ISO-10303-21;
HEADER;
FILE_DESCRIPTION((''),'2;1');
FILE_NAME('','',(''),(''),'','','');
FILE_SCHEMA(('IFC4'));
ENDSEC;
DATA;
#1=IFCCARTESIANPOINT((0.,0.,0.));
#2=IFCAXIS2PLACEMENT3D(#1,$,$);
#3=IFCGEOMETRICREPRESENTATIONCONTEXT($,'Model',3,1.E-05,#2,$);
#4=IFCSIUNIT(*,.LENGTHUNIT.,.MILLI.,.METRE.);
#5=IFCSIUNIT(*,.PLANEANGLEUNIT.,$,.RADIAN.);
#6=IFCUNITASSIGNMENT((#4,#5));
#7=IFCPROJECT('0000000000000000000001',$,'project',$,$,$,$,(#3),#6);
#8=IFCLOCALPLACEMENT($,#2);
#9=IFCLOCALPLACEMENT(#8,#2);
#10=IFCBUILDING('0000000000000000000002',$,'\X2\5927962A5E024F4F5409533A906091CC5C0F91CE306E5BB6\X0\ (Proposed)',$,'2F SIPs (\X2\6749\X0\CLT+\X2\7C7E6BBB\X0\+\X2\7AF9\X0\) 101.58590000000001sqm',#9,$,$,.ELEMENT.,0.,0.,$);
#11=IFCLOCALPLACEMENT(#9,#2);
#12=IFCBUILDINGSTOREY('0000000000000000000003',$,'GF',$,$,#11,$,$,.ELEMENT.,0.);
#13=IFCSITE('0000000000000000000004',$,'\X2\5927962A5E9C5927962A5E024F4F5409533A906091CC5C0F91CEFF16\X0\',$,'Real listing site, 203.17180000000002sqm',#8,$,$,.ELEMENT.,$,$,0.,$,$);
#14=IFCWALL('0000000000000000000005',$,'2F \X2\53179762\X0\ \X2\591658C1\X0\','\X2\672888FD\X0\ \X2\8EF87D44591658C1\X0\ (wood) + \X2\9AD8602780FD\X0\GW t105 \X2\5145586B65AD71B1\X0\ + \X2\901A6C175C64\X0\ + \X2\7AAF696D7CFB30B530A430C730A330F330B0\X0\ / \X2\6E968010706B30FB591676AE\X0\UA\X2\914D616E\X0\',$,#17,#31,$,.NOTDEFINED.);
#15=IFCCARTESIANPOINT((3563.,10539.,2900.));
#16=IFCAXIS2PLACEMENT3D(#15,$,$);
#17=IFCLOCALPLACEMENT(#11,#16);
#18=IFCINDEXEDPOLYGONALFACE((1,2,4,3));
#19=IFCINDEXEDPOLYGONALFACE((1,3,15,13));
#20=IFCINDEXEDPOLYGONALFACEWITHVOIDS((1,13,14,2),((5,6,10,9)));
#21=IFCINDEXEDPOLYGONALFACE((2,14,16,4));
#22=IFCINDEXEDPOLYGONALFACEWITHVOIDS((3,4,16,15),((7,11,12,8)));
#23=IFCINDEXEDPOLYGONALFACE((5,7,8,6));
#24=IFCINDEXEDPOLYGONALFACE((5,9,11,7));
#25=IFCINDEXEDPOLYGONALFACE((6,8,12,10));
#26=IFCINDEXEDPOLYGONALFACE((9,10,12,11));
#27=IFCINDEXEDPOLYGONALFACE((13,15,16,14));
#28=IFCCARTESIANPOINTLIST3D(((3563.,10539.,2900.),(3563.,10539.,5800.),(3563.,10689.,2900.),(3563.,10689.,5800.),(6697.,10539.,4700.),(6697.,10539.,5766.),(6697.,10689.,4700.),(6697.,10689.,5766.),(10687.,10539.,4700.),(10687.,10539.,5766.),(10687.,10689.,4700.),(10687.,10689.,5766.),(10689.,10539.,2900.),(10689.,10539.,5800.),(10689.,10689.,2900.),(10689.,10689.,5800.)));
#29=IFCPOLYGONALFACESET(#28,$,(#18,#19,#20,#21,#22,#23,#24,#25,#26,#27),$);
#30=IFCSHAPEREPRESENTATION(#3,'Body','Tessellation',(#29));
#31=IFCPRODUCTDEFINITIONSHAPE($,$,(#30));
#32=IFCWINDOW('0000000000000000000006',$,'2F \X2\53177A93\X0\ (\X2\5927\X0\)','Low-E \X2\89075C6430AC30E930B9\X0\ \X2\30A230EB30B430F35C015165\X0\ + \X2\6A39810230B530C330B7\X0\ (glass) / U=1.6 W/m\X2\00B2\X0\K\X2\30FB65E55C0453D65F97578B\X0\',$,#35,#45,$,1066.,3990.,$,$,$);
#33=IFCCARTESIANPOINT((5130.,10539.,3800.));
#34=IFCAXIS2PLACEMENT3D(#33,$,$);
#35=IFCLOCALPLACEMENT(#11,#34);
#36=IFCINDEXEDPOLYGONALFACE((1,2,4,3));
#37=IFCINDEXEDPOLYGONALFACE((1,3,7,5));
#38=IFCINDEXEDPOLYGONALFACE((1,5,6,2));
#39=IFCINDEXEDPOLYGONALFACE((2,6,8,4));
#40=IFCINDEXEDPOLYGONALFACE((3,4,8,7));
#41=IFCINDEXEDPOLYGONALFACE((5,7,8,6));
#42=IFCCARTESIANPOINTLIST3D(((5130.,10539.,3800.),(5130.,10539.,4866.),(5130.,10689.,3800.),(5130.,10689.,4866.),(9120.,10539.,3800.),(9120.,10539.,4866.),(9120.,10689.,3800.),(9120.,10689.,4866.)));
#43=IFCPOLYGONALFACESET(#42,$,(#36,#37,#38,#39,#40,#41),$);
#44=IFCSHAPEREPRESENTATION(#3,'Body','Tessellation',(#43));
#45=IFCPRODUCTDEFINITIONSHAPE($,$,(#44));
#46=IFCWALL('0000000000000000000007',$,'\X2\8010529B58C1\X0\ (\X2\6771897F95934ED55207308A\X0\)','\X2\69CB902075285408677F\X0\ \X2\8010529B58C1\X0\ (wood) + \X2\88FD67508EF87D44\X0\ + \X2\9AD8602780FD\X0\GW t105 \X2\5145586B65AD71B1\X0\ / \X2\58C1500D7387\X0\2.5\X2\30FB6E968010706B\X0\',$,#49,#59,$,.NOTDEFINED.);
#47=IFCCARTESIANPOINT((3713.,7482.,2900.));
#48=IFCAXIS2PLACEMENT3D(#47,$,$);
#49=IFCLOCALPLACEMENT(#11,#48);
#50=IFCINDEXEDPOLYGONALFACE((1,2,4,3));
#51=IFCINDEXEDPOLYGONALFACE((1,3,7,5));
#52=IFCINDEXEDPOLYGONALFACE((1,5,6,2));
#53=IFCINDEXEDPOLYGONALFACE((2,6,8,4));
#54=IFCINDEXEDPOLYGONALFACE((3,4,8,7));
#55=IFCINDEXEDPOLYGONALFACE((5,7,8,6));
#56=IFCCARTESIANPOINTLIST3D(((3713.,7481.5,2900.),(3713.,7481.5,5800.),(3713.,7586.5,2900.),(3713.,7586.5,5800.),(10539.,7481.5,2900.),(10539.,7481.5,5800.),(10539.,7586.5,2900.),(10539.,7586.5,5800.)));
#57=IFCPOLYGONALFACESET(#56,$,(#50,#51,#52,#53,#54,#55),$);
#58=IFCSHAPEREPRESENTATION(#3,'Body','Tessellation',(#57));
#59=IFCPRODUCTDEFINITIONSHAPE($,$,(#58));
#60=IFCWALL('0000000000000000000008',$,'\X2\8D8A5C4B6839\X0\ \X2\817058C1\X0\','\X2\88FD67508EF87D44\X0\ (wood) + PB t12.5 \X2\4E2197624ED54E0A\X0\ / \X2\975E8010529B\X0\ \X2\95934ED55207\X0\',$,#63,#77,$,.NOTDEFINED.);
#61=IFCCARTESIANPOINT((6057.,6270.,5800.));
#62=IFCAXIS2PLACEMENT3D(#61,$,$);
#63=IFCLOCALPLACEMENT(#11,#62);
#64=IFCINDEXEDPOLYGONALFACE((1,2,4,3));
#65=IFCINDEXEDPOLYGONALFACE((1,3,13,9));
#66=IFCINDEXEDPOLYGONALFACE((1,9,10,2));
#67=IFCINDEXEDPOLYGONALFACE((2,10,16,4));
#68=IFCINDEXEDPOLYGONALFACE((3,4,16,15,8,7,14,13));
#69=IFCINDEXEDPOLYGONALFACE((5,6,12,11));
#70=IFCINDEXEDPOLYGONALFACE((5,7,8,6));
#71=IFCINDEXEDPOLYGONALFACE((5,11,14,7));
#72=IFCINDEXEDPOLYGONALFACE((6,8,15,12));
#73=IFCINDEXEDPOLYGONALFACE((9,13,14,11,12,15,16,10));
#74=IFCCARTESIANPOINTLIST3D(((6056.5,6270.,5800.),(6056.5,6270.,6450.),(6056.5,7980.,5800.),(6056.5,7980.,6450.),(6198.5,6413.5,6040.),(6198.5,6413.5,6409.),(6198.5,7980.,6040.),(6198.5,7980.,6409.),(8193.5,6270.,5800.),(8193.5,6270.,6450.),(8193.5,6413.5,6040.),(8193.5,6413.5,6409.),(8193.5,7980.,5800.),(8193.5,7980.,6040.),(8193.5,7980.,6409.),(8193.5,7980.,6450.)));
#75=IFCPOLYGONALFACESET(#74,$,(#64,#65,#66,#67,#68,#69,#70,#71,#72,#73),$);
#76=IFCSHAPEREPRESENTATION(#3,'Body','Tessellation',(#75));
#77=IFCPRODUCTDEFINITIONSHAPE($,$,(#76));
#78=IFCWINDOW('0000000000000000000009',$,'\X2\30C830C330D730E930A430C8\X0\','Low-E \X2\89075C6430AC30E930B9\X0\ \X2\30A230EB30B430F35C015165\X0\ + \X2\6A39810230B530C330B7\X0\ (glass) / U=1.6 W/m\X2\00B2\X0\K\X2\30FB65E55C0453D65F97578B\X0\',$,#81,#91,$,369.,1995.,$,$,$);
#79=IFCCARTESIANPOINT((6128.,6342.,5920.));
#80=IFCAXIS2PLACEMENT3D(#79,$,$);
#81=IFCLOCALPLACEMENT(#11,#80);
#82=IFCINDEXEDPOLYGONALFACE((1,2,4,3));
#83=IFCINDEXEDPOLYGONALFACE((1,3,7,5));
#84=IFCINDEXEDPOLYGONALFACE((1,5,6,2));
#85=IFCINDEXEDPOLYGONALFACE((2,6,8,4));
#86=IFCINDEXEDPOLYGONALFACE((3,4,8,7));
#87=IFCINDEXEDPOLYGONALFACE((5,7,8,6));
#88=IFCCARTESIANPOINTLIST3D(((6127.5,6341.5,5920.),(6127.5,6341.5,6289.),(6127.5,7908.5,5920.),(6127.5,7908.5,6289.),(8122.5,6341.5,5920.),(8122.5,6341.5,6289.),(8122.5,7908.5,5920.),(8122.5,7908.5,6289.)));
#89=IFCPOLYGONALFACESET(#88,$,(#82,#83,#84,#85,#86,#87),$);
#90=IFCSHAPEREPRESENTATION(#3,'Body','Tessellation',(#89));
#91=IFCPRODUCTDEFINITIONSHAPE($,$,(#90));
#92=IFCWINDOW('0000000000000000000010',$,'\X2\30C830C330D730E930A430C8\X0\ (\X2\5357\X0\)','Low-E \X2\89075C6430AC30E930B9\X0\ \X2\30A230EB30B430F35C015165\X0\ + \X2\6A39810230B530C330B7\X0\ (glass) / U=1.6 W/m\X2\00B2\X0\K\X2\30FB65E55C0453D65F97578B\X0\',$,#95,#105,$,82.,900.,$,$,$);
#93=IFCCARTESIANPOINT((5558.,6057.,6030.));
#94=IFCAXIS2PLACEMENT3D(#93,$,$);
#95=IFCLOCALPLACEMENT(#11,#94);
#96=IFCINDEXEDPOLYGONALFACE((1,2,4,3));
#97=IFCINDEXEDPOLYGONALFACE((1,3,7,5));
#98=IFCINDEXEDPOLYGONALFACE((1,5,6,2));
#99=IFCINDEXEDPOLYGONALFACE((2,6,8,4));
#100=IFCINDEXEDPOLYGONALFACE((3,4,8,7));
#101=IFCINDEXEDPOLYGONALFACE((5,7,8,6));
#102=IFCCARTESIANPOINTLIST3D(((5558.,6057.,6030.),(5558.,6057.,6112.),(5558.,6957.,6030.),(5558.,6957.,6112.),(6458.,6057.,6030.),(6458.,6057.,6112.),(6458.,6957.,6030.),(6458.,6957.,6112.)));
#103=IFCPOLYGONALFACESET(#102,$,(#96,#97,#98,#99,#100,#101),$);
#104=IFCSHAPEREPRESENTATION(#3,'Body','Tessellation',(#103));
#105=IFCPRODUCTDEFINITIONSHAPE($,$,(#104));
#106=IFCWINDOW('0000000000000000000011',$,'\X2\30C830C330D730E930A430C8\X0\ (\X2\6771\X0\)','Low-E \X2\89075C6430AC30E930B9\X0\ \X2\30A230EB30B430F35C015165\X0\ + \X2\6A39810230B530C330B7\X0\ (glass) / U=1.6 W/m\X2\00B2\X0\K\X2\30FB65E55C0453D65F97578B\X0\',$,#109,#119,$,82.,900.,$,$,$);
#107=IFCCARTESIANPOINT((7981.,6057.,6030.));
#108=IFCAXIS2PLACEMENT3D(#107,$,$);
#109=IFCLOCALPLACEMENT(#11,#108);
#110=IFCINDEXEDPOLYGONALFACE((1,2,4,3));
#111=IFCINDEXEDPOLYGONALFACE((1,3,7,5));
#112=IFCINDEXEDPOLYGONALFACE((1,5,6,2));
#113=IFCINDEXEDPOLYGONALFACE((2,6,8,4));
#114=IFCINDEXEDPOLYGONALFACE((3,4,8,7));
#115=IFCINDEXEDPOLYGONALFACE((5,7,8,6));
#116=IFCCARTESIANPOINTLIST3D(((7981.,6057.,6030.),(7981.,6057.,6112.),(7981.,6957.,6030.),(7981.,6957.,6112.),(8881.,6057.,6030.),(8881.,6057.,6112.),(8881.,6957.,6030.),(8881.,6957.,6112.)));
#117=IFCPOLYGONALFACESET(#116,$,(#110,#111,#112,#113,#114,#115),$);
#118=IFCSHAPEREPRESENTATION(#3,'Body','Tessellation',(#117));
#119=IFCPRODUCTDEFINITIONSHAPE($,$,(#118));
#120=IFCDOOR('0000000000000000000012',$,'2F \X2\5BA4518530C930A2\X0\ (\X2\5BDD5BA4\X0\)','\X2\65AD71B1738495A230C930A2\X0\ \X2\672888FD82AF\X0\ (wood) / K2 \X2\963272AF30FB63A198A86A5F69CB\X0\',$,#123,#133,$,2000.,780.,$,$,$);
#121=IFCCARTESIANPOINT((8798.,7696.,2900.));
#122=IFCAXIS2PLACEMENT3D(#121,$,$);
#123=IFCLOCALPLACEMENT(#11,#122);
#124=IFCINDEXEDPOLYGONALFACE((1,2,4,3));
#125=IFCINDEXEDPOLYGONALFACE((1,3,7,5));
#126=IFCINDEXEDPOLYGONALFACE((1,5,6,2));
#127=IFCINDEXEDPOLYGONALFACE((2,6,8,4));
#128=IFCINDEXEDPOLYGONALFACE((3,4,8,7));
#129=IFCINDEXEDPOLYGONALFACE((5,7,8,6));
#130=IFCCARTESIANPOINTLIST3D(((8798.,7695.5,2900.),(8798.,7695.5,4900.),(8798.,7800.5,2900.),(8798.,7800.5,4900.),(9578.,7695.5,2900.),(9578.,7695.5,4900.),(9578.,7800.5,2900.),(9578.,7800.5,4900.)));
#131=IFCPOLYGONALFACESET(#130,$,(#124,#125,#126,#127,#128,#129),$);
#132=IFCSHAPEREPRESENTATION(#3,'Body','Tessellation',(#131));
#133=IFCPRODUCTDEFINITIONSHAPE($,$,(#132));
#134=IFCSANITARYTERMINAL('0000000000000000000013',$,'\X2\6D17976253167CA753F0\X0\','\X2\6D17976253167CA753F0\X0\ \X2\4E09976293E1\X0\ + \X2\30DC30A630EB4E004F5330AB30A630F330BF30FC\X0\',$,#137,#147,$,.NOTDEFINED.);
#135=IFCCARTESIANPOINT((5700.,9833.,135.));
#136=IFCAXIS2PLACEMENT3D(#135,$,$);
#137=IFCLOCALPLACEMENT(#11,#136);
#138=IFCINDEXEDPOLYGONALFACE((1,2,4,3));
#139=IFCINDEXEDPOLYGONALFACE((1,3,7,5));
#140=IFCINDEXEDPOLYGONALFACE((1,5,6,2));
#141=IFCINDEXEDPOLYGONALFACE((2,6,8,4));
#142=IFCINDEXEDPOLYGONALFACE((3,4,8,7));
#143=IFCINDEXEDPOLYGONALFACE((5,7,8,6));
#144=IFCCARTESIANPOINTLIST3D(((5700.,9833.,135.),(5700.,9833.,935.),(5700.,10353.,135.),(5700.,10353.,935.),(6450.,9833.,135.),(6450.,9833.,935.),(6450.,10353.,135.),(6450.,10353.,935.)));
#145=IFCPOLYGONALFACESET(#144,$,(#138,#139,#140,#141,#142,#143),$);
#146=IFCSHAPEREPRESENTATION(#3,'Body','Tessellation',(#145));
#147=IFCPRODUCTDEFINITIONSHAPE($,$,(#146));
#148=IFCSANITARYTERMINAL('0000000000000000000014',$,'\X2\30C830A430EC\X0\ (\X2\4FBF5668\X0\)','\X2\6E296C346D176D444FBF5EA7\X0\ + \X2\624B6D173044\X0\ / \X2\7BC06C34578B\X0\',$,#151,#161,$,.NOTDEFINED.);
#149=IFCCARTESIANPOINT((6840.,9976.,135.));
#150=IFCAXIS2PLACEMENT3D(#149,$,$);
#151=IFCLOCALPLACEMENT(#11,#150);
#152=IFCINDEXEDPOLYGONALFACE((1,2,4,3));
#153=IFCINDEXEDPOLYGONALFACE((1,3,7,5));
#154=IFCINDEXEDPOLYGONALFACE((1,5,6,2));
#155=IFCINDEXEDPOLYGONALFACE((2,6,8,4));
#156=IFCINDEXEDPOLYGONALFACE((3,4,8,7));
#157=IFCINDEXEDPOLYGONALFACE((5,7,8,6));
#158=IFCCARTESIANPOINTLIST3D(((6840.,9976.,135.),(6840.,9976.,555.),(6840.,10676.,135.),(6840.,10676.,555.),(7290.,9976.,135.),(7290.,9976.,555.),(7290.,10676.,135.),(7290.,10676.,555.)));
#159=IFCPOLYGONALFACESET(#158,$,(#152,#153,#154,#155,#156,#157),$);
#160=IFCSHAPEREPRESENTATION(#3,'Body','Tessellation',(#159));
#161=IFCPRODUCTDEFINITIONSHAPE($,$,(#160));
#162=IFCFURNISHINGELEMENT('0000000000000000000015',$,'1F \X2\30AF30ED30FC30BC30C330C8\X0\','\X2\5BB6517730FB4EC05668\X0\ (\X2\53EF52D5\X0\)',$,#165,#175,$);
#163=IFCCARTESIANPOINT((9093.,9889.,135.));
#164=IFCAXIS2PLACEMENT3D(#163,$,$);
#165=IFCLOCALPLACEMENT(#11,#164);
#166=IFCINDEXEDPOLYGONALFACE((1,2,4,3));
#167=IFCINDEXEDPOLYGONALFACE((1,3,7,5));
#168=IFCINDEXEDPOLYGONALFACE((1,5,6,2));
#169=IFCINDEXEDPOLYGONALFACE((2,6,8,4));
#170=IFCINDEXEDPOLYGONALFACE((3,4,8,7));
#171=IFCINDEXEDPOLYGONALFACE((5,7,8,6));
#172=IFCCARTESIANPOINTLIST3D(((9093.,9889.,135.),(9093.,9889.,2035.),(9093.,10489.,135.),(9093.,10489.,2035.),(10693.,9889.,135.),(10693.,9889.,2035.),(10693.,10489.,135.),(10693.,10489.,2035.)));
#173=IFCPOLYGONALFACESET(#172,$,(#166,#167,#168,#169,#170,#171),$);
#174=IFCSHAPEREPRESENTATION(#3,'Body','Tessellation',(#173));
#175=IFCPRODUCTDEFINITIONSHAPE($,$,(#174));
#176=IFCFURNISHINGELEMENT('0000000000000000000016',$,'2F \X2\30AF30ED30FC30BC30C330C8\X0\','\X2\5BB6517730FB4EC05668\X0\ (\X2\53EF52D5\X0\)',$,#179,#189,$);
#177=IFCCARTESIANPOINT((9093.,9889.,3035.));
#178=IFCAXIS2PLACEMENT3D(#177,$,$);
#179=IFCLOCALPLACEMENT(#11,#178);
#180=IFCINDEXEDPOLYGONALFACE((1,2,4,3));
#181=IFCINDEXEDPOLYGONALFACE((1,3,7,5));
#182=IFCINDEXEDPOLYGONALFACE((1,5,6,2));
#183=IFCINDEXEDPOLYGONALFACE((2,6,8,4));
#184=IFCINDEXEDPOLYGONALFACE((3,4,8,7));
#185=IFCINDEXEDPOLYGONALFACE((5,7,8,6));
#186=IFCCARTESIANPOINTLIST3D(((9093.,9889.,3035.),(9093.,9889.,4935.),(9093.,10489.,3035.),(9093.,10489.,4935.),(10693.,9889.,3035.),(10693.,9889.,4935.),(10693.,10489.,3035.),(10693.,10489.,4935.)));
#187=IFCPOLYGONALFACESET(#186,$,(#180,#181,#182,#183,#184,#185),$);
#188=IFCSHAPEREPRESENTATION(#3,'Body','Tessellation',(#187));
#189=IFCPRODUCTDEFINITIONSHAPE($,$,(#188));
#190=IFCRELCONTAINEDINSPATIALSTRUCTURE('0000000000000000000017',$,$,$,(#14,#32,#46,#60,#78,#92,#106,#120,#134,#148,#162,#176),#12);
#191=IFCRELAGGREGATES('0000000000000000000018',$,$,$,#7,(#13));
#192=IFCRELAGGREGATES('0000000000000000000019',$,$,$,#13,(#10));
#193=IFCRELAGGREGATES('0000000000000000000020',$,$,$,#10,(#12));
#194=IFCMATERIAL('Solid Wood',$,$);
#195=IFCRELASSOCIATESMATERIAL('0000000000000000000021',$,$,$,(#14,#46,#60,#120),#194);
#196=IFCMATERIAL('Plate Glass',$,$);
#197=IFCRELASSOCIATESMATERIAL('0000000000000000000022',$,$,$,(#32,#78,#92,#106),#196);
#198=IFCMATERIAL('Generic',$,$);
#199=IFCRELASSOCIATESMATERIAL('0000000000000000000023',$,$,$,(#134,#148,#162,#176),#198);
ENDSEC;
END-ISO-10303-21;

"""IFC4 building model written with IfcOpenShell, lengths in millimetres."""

from ifc_helpers import new_model, si_unit, frame, frame_2d, origin, place, context, project, spatial, rectangle, extrude, material, element, fill, save


model = new_model("IFC4")

# Units and contexts
model_context = context("Model", 3, precision=1e-05, world=origin())
ifc_project = project(units=[si_unit("LENGTHUNIT", "METRE", prefix="MILLI"), si_unit("PLANEANGLEUNIT", "RADIAN")], contexts=[model_context])

# Site, building, storey
site_placement = place(None, origin())
site = spatial("IfcSite", under=ifc_project, at=site_placement, Name="大阪府大阪市住吉区遠里小野６", ObjectType="Real listing site, 203.17180000000002sqm", CompositionType="ELEMENT", RefElevation=0.0)
building_placement = place(site_placement, origin())
building = spatial("IfcBuilding", under=site, at=building_placement, Name="大阪市住吉区遠里小野の家 (Proposed)", ObjectType="2F SIPs (杉CLT+籾殻+竹) 101.58590000000001sqm", CompositionType="ELEMENT", ElevationOfRefHeight=0.0, ElevationOfTerrain=0.0)
storey_placement = place(building_placement, origin())
storey = spatial("IfcBuildingStorey", under=building, at=storey_placement, Name="GF", CompositionType="ELEMENT", Elevation=0.0)

# Wall, opening, window
ifc_material_1 = material(Name="Solid Wood")
wall_1_placement = place(storey_placement, frame((3563.0, 10539.0, 2900.0)))
wall_1 = element("IfcWall", 1, at=wall_1_placement, inside=storey, material=ifc_material_1, Name="2F 北面 外壁", Description="木製 軸組外壁 (wood) + 高性能GW t105 充填断熱 + 通気層 + 窯業系サイディング / 準耐火・外皮UA配慮", PredefinedType="NOTDEFINED", context=model_context, shape_type="SweptSolid", body=[
    extrude(rectangle(XDim=7126.0, YDim=150.0, at=frame_2d((3563.0, 75.0))), frame((3563.0, 10539.0, 2900.0)), (0.0, 0.0, 1.0), 2900.0),
])
opening_1_placement = place(storey_placement, frame((5130.0, 10539.0, 3800.0)))
opening_1 = element("IfcOpeningElement", 2, at=opening_1_placement, cuts=wall_1, PredefinedType="NOTDEFINED", context=model_context, shape_type="SweptSolid", body=[
    extrude(rectangle(XDim=3990.0, YDim=150.0, at=frame_2d((1995.0, 75.0))), frame((5130.0, 10539.0, 3800.0)), (0.0, 0.0, 1.0), 1066.0),
])
ifc_material_2 = material(Name="Plate Glass")
window_1_placement = place(storey_placement, frame((5130.0, 10539.0, 3800.0)))
window_1 = element("IfcWindow", 3, at=window_1_placement, inside=storey, material=ifc_material_2, Name="2F 北窓 (大)", Description="Low-E 複層ガラス アルゴン封入 + 樹脂サッシ (glass) / U=1.6 W/m²K・日射取得型", OverallHeight=1066.0, OverallWidth=3990.0, context=model_context, shape_type="SweptSolid", body=[
    extrude(rectangle(XDim=3990.0, YDim=150.0, at=frame_2d((1995.0, 75.0))), frame((5130.0, 10539.0, 3800.0)), (0.0, 0.0, 1.0), 1066.0),
])
fill(opening_1, window_1)

# Wall
wall_2_placement = place(storey_placement, frame((3713.0, 7482.0, 2900.0)))
element("IfcWall", 4, at=wall_2_placement, inside=storey, material=ifc_material_1, Name="耐力壁 (東西間仕切り)", Description="構造用合板 耐力壁 (wood) + 製材軸組 + 高性能GW t105 充填断熱 / 壁倍率2.5・準耐火", PredefinedType="NOTDEFINED", context=model_context, shape_type="SweptSolid", body=[
    extrude(rectangle(XDim=6826.0, YDim=105.0, at=frame_2d((3413.0, 52.0))), frame((3713.0, 7482.0, 2900.0)), (0.0, 0.0, 1.0), 2900.0),
])

# Wall, openings, windows
wall_3_placement = place(storey_placement, frame((6057.0, 6270.0, 5800.0)))
wall_3 = element("IfcWall", 5, at=wall_3_placement, inside=storey, material=ifc_material_1, Name="越屋根 腰壁", Description="製材軸組 (wood) + PB t12.5 両面仕上 / 非耐力 間仕切", PredefinedType="NOTDEFINED", context=model_context, shape_type="SweptSolid", body=[
    extrude(rectangle(XDim=2137.0, YDim=1710.0, at=frame_2d((1068.0, 855.0))), frame((6057.0, 6270.0, 5800.0)), (0.0, 0.0, 1.0), 650.0),
])
opening_2_placement = place(storey_placement, frame((6128.0, 6342.0, 5920.0)))
opening_2 = element("IfcOpeningElement", 6, at=opening_2_placement, cuts=wall_3, PredefinedType="NOTDEFINED", context=model_context, shape_type="SweptSolid", body=[
    extrude(rectangle(XDim=1995.0, YDim=1567.0, at=frame_2d((997.0, 783.0))), frame((6128.0, 6342.0, 5920.0)), (0.0, 0.0, 1.0), 369.0),
])
opening_3_placement = place(storey_placement, frame((5558.0, 6057.0, 6030.0)))
opening_3 = element("IfcOpeningElement", 7, at=opening_3_placement, cuts=wall_3, PredefinedType="NOTDEFINED", context=model_context, shape_type="SweptSolid", body=[
    extrude(rectangle(XDim=900.0, YDim=900.0, at=frame_2d((450.0, 450.0))), frame((5558.0, 6057.0, 6030.0)), (0.0, 0.0, 1.0), 82.0),
])
opening_4_placement = place(storey_placement, frame((7981.0, 6057.0, 6030.0)))
opening_4 = element("IfcOpeningElement", 8, at=opening_4_placement, cuts=wall_3, PredefinedType="NOTDEFINED", context=model_context, shape_type="SweptSolid", body=[
    extrude(rectangle(XDim=900.0, YDim=900.0, at=frame_2d((450.0, 450.0))), frame((7981.0, 6057.0, 6030.0)), (0.0, 0.0, 1.0), 82.0),
])
window_2_placement = place(storey_placement, frame((6128.0, 6342.0, 5920.0)))
window_2 = element("IfcWindow", 9, at=window_2_placement, inside=storey, material=ifc_material_2, Name="トップライト", Description="Low-E 複層ガラス アルゴン封入 + 樹脂サッシ (glass) / U=1.6 W/m²K・日射取得型", OverallHeight=369.0, OverallWidth=1995.0, context=model_context, shape_type="SweptSolid", body=[
    extrude(rectangle(XDim=1995.0, YDim=1567.0, at=frame_2d((997.0, 783.0))), frame((6128.0, 6342.0, 5920.0)), (0.0, 0.0, 1.0), 369.0),
])
fill(opening_2, window_2)
window_3_placement = place(storey_placement, frame((5558.0, 6057.0, 6030.0)))
window_3 = element("IfcWindow", 10, at=window_3_placement, inside=storey, material=ifc_material_2, Name="トップライト (南)", Description="Low-E 複層ガラス アルゴン封入 + 樹脂サッシ (glass) / U=1.6 W/m²K・日射取得型", OverallHeight=82.0, OverallWidth=900.0, context=model_context, shape_type="SweptSolid", body=[
    extrude(rectangle(XDim=900.0, YDim=900.0, at=frame_2d((450.0, 450.0))), frame((5558.0, 6057.0, 6030.0)), (0.0, 0.0, 1.0), 82.0),
])
fill(opening_3, window_3)
window_4_placement = place(storey_placement, frame((7981.0, 6057.0, 6030.0)))
window_4 = element("IfcWindow", 11, at=window_4_placement, inside=storey, material=ifc_material_2, Name="トップライト (東)", Description="Low-E 複層ガラス アルゴン封入 + 樹脂サッシ (glass) / U=1.6 W/m²K・日射取得型", OverallHeight=82.0, OverallWidth=900.0, context=model_context, shape_type="SweptSolid", body=[
    extrude(rectangle(XDim=900.0, YDim=900.0, at=frame_2d((450.0, 450.0))), frame((7981.0, 6057.0, 6030.0)), (0.0, 0.0, 1.0), 82.0),
])
fill(opening_4, window_4)

# Door
door_placement = place(storey_placement, frame((8798.0, 7696.0, 2900.0)))
element("IfcDoor", 12, at=door_placement, inside=storey, material=ifc_material_1, Name="2F 室内ドア (寝室)", Description="断熱玄関ドア 木製芯 (wood) / K2 防犯・採風機構", OverallHeight=2000.0, OverallWidth=780.0, context=model_context, shape_type="SweptSolid", body=[
    extrude(rectangle(XDim=780.0, YDim=105.0, at=frame_2d((390.0, 52.0))), frame((8798.0, 7696.0, 2900.0)), (0.0, 0.0, 1.0), 2000.0),
])

# Sanitary terminals
ifc_material_3 = material(Name="Generic")
sanitary_terminal_1_placement = place(storey_placement, frame((5700.0, 9833.0, 135.0)))
element("IfcSanitaryTerminal", 13, at=sanitary_terminal_1_placement, inside=storey, material=ifc_material_3, Name="洗面化粧台", Description="洗面化粧台 三面鏡 + ボウル一体カウンター", PredefinedType="NOTDEFINED", context=model_context, shape_type="SweptSolid", body=[
    extrude(rectangle(XDim=750.0, YDim=520.0, at=frame_2d((375.0, 260.0))), frame((5700.0, 9833.0, 135.0)), (0.0, 0.0, 1.0), 800.0),
])
sanitary_terminal_2_placement = place(storey_placement, frame((6840.0, 9976.0, 135.0)))
element("IfcSanitaryTerminal", 14, at=sanitary_terminal_2_placement, inside=storey, material=ifc_material_3, Name="トイレ (便器)", Description="温水洗浄便座 + 手洗い / 節水型", PredefinedType="NOTDEFINED", context=model_context, shape_type="SweptSolid", body=[
    extrude(rectangle(XDim=450.0, YDim=700.0, at=frame_2d((225.0, 350.0))), frame((6840.0, 9976.0, 135.0)), (0.0, 0.0, 1.0), 420.0),
])

# Furnishing elements
furnishing_1_placement = place(storey_placement, frame((9093.0, 9889.0, 135.0)))
element("IfcFurnishingElement", 15, at=furnishing_1_placement, inside=storey, material=ifc_material_3, Name="1F クローゼット", Description="家具・什器 (可動)", context=model_context, shape_type="SweptSolid", body=[
    extrude(rectangle(XDim=1600.0, YDim=600.0, at=frame_2d((800.0, 300.0))), frame((9093.0, 9889.0, 135.0)), (0.0, 0.0, 1.0), 1900.0),
])
furnishing_2_placement = place(storey_placement, frame((9093.0, 9889.0, 3035.0)))
element("IfcFurnishingElement", 16, at=furnishing_2_placement, inside=storey, material=ifc_material_3, Name="2F クローゼット", Description="家具・什器 (可動)", context=model_context, shape_type="SweptSolid", body=[
    extrude(rectangle(XDim=1600.0, YDim=600.0, at=frame_2d((800.0, 300.0))), frame((9093.0, 9889.0, 3035.0)), (0.0, 0.0, 1.0), 1900.0),
])

save(model, "model.ifc")
